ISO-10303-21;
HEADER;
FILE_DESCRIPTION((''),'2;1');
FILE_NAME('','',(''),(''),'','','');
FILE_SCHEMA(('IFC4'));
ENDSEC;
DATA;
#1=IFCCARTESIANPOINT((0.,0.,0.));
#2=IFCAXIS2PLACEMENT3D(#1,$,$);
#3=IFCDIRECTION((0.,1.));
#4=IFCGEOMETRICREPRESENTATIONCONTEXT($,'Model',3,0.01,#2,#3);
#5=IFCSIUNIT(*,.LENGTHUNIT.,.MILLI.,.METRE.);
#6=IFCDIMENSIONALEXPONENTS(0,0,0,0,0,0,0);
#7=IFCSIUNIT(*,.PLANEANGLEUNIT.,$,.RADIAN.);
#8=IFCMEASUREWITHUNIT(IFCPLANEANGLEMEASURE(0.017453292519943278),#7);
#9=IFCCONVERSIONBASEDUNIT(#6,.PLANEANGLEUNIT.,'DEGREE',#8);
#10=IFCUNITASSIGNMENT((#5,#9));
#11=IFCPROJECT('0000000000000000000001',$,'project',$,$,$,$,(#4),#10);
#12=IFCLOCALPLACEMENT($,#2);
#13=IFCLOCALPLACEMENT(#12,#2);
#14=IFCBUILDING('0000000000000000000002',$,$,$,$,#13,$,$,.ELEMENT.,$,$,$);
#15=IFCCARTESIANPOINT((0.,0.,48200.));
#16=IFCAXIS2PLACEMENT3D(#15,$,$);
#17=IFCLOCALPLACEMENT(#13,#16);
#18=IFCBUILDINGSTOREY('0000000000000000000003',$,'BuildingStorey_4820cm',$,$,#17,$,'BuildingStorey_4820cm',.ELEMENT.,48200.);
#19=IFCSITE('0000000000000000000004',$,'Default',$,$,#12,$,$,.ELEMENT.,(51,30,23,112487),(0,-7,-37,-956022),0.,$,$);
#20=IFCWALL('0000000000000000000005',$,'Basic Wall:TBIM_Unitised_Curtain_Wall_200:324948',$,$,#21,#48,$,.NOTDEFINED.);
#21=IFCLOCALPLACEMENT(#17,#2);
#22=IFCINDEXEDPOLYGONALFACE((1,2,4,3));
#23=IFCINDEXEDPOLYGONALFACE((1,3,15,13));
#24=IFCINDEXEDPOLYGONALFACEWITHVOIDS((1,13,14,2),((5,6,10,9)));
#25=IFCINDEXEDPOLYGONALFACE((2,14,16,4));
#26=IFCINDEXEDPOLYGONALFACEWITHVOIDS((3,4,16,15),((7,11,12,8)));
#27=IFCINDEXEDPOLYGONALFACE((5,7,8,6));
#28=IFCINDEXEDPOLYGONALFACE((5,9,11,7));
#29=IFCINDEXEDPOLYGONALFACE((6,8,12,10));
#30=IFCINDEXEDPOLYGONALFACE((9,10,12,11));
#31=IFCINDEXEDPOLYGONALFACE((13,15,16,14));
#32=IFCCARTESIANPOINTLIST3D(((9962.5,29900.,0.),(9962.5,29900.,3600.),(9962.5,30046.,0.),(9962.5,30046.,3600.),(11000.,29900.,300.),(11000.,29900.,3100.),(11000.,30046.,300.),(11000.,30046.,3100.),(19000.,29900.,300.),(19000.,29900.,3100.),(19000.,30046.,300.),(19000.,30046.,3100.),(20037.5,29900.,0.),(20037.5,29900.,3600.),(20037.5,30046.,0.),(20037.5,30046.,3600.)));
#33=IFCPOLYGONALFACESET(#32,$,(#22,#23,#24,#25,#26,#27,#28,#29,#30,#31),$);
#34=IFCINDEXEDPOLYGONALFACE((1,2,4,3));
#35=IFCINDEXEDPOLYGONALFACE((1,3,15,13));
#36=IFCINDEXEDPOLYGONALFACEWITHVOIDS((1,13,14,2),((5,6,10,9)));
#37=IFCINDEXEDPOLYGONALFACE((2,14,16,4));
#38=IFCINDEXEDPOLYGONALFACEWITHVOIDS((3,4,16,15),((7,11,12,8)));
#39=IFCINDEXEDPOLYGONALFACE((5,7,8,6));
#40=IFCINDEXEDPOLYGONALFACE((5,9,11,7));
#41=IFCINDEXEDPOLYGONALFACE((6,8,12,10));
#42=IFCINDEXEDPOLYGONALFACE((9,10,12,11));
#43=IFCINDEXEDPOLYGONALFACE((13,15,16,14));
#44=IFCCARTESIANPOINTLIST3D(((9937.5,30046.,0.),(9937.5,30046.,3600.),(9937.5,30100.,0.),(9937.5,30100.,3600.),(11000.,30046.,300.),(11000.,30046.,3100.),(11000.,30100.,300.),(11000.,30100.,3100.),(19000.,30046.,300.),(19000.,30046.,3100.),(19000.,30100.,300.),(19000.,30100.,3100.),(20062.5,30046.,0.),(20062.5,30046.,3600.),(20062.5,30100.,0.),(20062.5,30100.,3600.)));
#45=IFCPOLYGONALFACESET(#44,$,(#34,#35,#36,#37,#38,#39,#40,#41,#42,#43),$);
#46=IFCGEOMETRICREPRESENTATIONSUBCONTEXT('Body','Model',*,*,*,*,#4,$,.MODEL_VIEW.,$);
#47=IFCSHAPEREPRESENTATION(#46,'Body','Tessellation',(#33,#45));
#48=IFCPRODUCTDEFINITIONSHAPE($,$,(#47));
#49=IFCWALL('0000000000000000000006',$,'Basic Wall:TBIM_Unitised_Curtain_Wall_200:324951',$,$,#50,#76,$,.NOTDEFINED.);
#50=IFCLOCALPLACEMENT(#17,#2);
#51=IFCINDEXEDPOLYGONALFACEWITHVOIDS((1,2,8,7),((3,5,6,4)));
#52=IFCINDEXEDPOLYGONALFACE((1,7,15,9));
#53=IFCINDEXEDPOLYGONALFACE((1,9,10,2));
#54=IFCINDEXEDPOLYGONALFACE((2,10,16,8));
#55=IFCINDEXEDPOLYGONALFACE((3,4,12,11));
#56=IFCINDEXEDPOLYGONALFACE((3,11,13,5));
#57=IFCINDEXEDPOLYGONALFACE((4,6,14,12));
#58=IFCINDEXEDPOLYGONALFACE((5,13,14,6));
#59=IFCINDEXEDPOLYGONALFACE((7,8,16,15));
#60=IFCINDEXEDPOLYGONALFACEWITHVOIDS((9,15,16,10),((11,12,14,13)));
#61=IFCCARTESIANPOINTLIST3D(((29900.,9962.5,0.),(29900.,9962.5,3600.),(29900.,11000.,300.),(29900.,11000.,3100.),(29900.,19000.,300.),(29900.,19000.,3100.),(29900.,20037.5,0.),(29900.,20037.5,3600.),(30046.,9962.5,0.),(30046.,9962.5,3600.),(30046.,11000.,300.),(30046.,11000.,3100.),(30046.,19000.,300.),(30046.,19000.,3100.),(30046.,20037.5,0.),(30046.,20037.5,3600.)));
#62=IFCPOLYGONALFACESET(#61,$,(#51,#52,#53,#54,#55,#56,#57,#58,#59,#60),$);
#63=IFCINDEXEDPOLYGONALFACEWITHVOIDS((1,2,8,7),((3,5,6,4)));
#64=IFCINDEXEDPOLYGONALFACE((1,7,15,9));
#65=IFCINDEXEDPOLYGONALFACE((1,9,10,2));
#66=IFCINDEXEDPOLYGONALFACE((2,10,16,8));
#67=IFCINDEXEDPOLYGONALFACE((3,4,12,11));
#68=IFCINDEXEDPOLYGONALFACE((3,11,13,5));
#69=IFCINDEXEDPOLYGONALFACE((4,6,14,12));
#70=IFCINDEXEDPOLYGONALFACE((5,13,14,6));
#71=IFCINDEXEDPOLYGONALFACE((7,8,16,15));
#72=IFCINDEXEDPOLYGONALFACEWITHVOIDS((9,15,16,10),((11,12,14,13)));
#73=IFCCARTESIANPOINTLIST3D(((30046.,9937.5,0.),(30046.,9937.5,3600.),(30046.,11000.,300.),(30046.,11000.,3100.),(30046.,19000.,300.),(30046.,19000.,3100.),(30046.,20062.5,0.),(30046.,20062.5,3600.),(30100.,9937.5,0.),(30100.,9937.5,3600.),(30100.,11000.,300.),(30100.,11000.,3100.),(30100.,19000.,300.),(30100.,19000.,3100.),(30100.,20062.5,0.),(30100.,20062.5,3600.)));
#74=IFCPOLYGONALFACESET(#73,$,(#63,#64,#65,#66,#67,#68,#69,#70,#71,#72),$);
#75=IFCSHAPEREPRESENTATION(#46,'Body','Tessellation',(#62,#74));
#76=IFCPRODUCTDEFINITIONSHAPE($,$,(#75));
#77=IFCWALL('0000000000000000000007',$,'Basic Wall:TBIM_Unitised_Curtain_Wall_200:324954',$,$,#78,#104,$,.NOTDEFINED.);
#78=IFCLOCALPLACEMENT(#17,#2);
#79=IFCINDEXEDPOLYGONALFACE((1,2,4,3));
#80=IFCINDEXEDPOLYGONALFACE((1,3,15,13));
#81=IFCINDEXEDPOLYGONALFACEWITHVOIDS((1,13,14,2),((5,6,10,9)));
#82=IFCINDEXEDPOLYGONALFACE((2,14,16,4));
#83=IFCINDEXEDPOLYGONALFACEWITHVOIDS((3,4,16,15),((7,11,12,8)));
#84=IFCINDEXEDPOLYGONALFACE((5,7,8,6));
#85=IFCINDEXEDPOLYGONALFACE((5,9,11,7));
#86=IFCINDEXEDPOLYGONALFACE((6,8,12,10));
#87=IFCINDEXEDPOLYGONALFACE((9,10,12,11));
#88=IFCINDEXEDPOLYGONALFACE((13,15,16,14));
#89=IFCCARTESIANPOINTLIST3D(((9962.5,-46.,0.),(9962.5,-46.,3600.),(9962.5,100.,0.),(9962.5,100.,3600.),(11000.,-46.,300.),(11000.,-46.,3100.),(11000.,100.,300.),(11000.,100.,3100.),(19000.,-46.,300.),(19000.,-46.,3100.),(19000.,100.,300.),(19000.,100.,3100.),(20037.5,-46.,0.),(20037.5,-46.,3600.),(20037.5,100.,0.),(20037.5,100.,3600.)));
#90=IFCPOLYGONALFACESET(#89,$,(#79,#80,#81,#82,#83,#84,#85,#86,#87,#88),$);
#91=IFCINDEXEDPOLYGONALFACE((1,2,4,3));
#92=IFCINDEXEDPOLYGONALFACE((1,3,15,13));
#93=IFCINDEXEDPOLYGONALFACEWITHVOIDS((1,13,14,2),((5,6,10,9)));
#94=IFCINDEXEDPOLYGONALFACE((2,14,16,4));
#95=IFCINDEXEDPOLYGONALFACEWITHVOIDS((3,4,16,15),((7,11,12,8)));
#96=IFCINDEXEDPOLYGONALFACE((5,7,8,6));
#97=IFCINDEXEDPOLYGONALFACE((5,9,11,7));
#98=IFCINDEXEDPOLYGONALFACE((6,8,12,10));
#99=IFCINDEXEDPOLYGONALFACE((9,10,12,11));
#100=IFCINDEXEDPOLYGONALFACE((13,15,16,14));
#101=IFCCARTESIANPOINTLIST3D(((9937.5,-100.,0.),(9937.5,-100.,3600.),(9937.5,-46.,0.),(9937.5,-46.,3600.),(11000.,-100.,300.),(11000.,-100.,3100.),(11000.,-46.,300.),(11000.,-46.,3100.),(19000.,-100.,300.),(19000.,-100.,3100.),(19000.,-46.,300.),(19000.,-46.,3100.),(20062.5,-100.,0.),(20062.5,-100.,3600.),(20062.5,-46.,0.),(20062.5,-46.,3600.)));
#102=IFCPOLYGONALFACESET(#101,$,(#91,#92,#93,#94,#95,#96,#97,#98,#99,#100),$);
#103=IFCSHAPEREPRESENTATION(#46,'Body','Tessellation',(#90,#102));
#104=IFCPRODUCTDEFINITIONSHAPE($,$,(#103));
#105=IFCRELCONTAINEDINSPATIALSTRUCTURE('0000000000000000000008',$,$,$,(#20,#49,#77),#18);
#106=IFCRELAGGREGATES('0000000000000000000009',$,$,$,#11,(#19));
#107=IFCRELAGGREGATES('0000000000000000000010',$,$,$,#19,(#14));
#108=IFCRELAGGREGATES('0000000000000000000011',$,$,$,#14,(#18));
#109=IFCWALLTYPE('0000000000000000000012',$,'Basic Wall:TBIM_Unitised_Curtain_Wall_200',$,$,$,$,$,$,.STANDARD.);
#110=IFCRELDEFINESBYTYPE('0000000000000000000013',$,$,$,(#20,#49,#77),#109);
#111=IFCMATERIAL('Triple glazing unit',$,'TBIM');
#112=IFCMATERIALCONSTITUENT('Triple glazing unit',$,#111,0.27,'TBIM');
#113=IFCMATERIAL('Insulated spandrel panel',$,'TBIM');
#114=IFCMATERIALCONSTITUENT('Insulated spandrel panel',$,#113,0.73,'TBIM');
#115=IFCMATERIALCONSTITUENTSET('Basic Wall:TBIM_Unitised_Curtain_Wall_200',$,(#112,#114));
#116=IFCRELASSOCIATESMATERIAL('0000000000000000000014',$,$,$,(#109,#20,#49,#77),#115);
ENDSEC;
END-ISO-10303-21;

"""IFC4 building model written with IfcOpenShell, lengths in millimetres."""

from ifc_helpers import new_model, entity, si_unit, converted_unit, direction, frame, origin, place, context, subcontext, project, spatial, indexed_curve, outline, extrude, material, constituent, constituent_set, type_object, element, save


model = new_model("IFC4")

# Units and contexts
model_context = context("Model", 3, precision=0.01, world=origin(), true_north=direction((0.0, 1.0)))
body_context = subcontext(model_context, "Body", "Model", "MODEL_VIEW")
ifc_project = project(units=[si_unit("LENGTHUNIT", "METRE", prefix="MILLI"), converted_unit("PLANEANGLEUNIT", "DEGREE", entity("IfcPlaneAngleMeasure", 0.017453292519943278), si_unit("PLANEANGLEUNIT", "RADIAN"), dimensions=[0, 0, 0, 0, 0, 0, 0])], contexts=[model_context])

# Site, building, storey
site_placement = place(None, origin())
site = spatial("IfcSite", under=ifc_project, at=site_placement, Name="Default", CompositionType="ELEMENT", RefLatitude=(51, 30, 23, 112487), RefLongitude=(0, -7, -37, -956022), RefElevation=0.0)
building_placement = place(site_placement, origin())
building = spatial("IfcBuilding", under=site, at=building_placement, CompositionType="ELEMENT")
storey_placement = place(building_placement, frame((0.0, 0.0, 48200.0)))
storey = spatial("IfcBuildingStorey", under=building, at=storey_placement, Name="BuildingStorey_4820cm", LongName="BuildingStorey_4820cm", CompositionType="ELEMENT", Elevation=48200.0)

# Walls, openings
ifc_material_1 = material(Name="Triple glazing unit", Category="TBIM")
ifc_constituent_1 = constituent(ifc_material_1, Name="Triple glazing unit", Category="TBIM", fraction=0.27)
ifc_material_2 = material(Name="Insulated spandrel panel", Category="TBIM")
ifc_constituent_2 = constituent(ifc_material_2, Name="Insulated spandrel panel", Category="TBIM", fraction=0.73)
ifc_constituent_set_1 = constituent_set(constituents=[ifc_constituent_1, ifc_constituent_2], Name="Basic Wall:TBIM_Unitised_Curtain_Wall_200")
wall_type_1 = type_object("IfcWallType", Name="Basic Wall:TBIM_Unitised_Curtain_Wall_200", PredefinedType="STANDARD", material=ifc_constituent_set_1)
wall_1_placement = place(storey_placement, frame((9937.5, 30000.0, 0.0)))
wall_1 = element("IfcWall", 1, at=wall_1_placement, inside=storey, type_object=wall_type_1, material=ifc_constituent_set_1, Name="Basic Wall:TBIM_Unitised_Curtain_Wall_200:324948", PredefinedType="NOTDEFINED", context=body_context, shape_type="SweptSolid", body=[
    extrude(outline(indexed_curve([(-1800.0, -5037.5), (1800.0, -5037.5), (1800.0, -4937.5), (1800.0, 4937.5), (1800.0, 5037.5), (-1800.0, 5037.5), (-1800.0, 4937.5), (-1800.0, -4937.5), (-1800.0, -5037.5)], self_intersect=False), holes=[indexed_curve([(1300.0, -4000.0), (-1500.0, -4000.0), (-1500.0, 4000.0), (1300.0, 4000.0), (1300.0, -4000.0)], self_intersect=False)]), frame((5062.5, -100.0, 1800.0), z_axis=(0.0, 1.0, 0.0), x_axis=(0.0, 0.0, 1.0)), (0.0, 0.0, 1.0), 146.0),
    extrude(outline(indexed_curve([(-1800.0, -5062.5), (1800.0, -5062.5), (1800.0, 5062.5), (-1800.0, 5062.5), (-1800.0, -5062.5)], self_intersect=False), holes=[indexed_curve([(-1500.0, -4000.0), (-1500.0, 4000.0), (1300.0, 4000.0), (1300.0, -4000.0), (-1500.0, -4000.0)], self_intersect=False)]), frame((5062.5, 46.0, 1800.0), z_axis=(0.0, 1.0, 0.0), x_axis=(0.0, 0.0, 1.0)), (0.0, 0.0, 1.0), 54.0),
])
opening_1_placement = place(wall_1_placement, frame((1062.5, -100.0, 300.0)))
element("IfcOpeningElement", 2, at=opening_1_placement, cuts=wall_1, PredefinedType="OPENING", context=body_context, shape_type="SweptSolid", body=[
    extrude(outline(indexed_curve([(2800.0, 0.0), (2800.0, 8000.0), (0.0, 8000.0), (0.0, 0.0), (2800.0, 0.0)], self_intersect=False)), frame((0.0, 0.0, 0.0), z_axis=(0.0, 1.0, 0.0), x_axis=(0.0, 0.0, 1.0)), (0.0, 0.0, 1.0), 200.0),
])
wall_2_placement = place(storey_placement, frame((30000.0, 9937.5, 0.0), z_axis=(0.0, 0.0, 1.0), x_axis=(0.0, 1.0, 0.0)))
wall_2 = element("IfcWall", 3, at=wall_2_placement, inside=storey, type_object=wall_type_1, material=ifc_constituent_set_1, Name="Basic Wall:TBIM_Unitised_Curtain_Wall_200:324951", PredefinedType="NOTDEFINED", context=body_context, shape_type="SweptSolid", body=[
    extrude(outline(indexed_curve([(-5037.5, -1800.0), (-4937.5, -1800.0), (4937.5, -1800.0), (5037.5, -1800.0), (5037.5, 1800.0), (4937.5, 1800.0), (-4937.5, 1800.0), (-5037.5, 1800.0), (-5037.5, -1800.0)], self_intersect=False), holes=[indexed_curve([(-4000.0, 1300.0), (4000.0, 1300.0), (4000.0, -1500.0), (-4000.0, -1500.0), (-4000.0, 1300.0)], self_intersect=False)]), frame((5062.5, 100.0, 1800.0), z_axis=(0.0, -1.0, 0.0), x_axis=(1.0, 0.0, 0.0)), (0.0, 0.0, 1.0), 146.0),
    extrude(outline(indexed_curve([(-1800.0, -5062.5), (1800.0, -5062.5), (1800.0, 5062.5), (-1800.0, 5062.5), (-1800.0, -5062.5)], self_intersect=False), holes=[indexed_curve([(1300.0, 4000.0), (1300.0, -4000.0), (-1500.0, -4000.0), (-1500.0, 4000.0), (1300.0, 4000.0)], self_intersect=False)]), frame((5062.5, -46.0, 1800.0), z_axis=(0.0, -1.0, 0.0), x_axis=(0.0, 0.0, 1.0)), (0.0, 0.0, 1.0), 54.0),
])
opening_2_placement = place(wall_2_placement, frame((1062.5, -100.0, 300.0)))
element("IfcOpeningElement", 4, at=opening_2_placement, cuts=wall_2, PredefinedType="OPENING", context=body_context, shape_type="SweptSolid", body=[
    extrude(outline(indexed_curve([(2800.0, 0.0), (2800.0, 8000.0), (0.0, 8000.0), (0.0, 0.0), (2800.0, 0.0)], self_intersect=False)), frame((0.0, 0.0, 0.0), z_axis=(0.0, 1.0, 0.0), x_axis=(0.0, 0.0, 1.0)), (0.0, 0.0, 1.0), 200.0),
])
wall_3_placement = place(storey_placement, frame((9937.5, 0.0, 0.0)))
wall_3 = element("IfcWall", 5, at=wall_3_placement, inside=storey, type_object=wall_type_1, material=ifc_constituent_set_1, Name="Basic Wall:TBIM_Unitised_Curtain_Wall_200:324954", PredefinedType="NOTDEFINED", context=body_context, shape_type="SweptSolid", body=[
    extrude(outline(indexed_curve([(-1800.0, -5037.5), (1800.0, -5037.5), (1800.0, 5037.5), (-1800.0, 5037.5), (-1800.0, -5037.5)], self_intersect=False), holes=[indexed_curve([(-1500.0, -4000.0), (-1500.0, 4000.0), (1300.0, 4000.0), (1300.0, -4000.0), (-1500.0, -4000.0)], self_intersect=False)]), frame((5062.5, -46.0, 1800.0), z_axis=(0.0, 1.0, 0.0), x_axis=(0.0, 0.0, 1.0)), (0.0, 0.0, 1.0), 146.0),
    extrude(outline(indexed_curve([(-1800.0, -5062.5), (1800.0, -5062.5), (1800.0, 5062.5), (-1800.0, 5062.5), (-1800.0, -5062.5)], self_intersect=False), holes=[indexed_curve([(1300.0, -4000.0), (-1500.0, -4000.0), (-1500.0, 4000.0), (1300.0, 4000.0), (1300.0, -4000.0)], self_intersect=False)]), frame((5062.5, -100.0, 1800.0), z_axis=(0.0, 1.0, 0.0), x_axis=(0.0, 0.0, 1.0)), (0.0, 0.0, 1.0), 54.0),
])
opening_3_placement = place(wall_3_placement, frame((1062.5, -100.0, 300.0)))
element("IfcOpeningElement", 6, at=opening_3_placement, cuts=wall_3, PredefinedType="OPENING", context=body_context, shape_type="SweptSolid", body=[
    extrude(outline(indexed_curve([(2800.0, 0.0), (2800.0, 8000.0), (0.0, 8000.0), (0.0, 0.0), (2800.0, 0.0)], self_intersect=False)), frame((0.0, 0.0, 0.0), z_axis=(0.0, 1.0, 0.0), x_axis=(0.0, 0.0, 1.0)), (0.0, 0.0, 1.0), 200.0),
])

save(model, "model.ifc")
